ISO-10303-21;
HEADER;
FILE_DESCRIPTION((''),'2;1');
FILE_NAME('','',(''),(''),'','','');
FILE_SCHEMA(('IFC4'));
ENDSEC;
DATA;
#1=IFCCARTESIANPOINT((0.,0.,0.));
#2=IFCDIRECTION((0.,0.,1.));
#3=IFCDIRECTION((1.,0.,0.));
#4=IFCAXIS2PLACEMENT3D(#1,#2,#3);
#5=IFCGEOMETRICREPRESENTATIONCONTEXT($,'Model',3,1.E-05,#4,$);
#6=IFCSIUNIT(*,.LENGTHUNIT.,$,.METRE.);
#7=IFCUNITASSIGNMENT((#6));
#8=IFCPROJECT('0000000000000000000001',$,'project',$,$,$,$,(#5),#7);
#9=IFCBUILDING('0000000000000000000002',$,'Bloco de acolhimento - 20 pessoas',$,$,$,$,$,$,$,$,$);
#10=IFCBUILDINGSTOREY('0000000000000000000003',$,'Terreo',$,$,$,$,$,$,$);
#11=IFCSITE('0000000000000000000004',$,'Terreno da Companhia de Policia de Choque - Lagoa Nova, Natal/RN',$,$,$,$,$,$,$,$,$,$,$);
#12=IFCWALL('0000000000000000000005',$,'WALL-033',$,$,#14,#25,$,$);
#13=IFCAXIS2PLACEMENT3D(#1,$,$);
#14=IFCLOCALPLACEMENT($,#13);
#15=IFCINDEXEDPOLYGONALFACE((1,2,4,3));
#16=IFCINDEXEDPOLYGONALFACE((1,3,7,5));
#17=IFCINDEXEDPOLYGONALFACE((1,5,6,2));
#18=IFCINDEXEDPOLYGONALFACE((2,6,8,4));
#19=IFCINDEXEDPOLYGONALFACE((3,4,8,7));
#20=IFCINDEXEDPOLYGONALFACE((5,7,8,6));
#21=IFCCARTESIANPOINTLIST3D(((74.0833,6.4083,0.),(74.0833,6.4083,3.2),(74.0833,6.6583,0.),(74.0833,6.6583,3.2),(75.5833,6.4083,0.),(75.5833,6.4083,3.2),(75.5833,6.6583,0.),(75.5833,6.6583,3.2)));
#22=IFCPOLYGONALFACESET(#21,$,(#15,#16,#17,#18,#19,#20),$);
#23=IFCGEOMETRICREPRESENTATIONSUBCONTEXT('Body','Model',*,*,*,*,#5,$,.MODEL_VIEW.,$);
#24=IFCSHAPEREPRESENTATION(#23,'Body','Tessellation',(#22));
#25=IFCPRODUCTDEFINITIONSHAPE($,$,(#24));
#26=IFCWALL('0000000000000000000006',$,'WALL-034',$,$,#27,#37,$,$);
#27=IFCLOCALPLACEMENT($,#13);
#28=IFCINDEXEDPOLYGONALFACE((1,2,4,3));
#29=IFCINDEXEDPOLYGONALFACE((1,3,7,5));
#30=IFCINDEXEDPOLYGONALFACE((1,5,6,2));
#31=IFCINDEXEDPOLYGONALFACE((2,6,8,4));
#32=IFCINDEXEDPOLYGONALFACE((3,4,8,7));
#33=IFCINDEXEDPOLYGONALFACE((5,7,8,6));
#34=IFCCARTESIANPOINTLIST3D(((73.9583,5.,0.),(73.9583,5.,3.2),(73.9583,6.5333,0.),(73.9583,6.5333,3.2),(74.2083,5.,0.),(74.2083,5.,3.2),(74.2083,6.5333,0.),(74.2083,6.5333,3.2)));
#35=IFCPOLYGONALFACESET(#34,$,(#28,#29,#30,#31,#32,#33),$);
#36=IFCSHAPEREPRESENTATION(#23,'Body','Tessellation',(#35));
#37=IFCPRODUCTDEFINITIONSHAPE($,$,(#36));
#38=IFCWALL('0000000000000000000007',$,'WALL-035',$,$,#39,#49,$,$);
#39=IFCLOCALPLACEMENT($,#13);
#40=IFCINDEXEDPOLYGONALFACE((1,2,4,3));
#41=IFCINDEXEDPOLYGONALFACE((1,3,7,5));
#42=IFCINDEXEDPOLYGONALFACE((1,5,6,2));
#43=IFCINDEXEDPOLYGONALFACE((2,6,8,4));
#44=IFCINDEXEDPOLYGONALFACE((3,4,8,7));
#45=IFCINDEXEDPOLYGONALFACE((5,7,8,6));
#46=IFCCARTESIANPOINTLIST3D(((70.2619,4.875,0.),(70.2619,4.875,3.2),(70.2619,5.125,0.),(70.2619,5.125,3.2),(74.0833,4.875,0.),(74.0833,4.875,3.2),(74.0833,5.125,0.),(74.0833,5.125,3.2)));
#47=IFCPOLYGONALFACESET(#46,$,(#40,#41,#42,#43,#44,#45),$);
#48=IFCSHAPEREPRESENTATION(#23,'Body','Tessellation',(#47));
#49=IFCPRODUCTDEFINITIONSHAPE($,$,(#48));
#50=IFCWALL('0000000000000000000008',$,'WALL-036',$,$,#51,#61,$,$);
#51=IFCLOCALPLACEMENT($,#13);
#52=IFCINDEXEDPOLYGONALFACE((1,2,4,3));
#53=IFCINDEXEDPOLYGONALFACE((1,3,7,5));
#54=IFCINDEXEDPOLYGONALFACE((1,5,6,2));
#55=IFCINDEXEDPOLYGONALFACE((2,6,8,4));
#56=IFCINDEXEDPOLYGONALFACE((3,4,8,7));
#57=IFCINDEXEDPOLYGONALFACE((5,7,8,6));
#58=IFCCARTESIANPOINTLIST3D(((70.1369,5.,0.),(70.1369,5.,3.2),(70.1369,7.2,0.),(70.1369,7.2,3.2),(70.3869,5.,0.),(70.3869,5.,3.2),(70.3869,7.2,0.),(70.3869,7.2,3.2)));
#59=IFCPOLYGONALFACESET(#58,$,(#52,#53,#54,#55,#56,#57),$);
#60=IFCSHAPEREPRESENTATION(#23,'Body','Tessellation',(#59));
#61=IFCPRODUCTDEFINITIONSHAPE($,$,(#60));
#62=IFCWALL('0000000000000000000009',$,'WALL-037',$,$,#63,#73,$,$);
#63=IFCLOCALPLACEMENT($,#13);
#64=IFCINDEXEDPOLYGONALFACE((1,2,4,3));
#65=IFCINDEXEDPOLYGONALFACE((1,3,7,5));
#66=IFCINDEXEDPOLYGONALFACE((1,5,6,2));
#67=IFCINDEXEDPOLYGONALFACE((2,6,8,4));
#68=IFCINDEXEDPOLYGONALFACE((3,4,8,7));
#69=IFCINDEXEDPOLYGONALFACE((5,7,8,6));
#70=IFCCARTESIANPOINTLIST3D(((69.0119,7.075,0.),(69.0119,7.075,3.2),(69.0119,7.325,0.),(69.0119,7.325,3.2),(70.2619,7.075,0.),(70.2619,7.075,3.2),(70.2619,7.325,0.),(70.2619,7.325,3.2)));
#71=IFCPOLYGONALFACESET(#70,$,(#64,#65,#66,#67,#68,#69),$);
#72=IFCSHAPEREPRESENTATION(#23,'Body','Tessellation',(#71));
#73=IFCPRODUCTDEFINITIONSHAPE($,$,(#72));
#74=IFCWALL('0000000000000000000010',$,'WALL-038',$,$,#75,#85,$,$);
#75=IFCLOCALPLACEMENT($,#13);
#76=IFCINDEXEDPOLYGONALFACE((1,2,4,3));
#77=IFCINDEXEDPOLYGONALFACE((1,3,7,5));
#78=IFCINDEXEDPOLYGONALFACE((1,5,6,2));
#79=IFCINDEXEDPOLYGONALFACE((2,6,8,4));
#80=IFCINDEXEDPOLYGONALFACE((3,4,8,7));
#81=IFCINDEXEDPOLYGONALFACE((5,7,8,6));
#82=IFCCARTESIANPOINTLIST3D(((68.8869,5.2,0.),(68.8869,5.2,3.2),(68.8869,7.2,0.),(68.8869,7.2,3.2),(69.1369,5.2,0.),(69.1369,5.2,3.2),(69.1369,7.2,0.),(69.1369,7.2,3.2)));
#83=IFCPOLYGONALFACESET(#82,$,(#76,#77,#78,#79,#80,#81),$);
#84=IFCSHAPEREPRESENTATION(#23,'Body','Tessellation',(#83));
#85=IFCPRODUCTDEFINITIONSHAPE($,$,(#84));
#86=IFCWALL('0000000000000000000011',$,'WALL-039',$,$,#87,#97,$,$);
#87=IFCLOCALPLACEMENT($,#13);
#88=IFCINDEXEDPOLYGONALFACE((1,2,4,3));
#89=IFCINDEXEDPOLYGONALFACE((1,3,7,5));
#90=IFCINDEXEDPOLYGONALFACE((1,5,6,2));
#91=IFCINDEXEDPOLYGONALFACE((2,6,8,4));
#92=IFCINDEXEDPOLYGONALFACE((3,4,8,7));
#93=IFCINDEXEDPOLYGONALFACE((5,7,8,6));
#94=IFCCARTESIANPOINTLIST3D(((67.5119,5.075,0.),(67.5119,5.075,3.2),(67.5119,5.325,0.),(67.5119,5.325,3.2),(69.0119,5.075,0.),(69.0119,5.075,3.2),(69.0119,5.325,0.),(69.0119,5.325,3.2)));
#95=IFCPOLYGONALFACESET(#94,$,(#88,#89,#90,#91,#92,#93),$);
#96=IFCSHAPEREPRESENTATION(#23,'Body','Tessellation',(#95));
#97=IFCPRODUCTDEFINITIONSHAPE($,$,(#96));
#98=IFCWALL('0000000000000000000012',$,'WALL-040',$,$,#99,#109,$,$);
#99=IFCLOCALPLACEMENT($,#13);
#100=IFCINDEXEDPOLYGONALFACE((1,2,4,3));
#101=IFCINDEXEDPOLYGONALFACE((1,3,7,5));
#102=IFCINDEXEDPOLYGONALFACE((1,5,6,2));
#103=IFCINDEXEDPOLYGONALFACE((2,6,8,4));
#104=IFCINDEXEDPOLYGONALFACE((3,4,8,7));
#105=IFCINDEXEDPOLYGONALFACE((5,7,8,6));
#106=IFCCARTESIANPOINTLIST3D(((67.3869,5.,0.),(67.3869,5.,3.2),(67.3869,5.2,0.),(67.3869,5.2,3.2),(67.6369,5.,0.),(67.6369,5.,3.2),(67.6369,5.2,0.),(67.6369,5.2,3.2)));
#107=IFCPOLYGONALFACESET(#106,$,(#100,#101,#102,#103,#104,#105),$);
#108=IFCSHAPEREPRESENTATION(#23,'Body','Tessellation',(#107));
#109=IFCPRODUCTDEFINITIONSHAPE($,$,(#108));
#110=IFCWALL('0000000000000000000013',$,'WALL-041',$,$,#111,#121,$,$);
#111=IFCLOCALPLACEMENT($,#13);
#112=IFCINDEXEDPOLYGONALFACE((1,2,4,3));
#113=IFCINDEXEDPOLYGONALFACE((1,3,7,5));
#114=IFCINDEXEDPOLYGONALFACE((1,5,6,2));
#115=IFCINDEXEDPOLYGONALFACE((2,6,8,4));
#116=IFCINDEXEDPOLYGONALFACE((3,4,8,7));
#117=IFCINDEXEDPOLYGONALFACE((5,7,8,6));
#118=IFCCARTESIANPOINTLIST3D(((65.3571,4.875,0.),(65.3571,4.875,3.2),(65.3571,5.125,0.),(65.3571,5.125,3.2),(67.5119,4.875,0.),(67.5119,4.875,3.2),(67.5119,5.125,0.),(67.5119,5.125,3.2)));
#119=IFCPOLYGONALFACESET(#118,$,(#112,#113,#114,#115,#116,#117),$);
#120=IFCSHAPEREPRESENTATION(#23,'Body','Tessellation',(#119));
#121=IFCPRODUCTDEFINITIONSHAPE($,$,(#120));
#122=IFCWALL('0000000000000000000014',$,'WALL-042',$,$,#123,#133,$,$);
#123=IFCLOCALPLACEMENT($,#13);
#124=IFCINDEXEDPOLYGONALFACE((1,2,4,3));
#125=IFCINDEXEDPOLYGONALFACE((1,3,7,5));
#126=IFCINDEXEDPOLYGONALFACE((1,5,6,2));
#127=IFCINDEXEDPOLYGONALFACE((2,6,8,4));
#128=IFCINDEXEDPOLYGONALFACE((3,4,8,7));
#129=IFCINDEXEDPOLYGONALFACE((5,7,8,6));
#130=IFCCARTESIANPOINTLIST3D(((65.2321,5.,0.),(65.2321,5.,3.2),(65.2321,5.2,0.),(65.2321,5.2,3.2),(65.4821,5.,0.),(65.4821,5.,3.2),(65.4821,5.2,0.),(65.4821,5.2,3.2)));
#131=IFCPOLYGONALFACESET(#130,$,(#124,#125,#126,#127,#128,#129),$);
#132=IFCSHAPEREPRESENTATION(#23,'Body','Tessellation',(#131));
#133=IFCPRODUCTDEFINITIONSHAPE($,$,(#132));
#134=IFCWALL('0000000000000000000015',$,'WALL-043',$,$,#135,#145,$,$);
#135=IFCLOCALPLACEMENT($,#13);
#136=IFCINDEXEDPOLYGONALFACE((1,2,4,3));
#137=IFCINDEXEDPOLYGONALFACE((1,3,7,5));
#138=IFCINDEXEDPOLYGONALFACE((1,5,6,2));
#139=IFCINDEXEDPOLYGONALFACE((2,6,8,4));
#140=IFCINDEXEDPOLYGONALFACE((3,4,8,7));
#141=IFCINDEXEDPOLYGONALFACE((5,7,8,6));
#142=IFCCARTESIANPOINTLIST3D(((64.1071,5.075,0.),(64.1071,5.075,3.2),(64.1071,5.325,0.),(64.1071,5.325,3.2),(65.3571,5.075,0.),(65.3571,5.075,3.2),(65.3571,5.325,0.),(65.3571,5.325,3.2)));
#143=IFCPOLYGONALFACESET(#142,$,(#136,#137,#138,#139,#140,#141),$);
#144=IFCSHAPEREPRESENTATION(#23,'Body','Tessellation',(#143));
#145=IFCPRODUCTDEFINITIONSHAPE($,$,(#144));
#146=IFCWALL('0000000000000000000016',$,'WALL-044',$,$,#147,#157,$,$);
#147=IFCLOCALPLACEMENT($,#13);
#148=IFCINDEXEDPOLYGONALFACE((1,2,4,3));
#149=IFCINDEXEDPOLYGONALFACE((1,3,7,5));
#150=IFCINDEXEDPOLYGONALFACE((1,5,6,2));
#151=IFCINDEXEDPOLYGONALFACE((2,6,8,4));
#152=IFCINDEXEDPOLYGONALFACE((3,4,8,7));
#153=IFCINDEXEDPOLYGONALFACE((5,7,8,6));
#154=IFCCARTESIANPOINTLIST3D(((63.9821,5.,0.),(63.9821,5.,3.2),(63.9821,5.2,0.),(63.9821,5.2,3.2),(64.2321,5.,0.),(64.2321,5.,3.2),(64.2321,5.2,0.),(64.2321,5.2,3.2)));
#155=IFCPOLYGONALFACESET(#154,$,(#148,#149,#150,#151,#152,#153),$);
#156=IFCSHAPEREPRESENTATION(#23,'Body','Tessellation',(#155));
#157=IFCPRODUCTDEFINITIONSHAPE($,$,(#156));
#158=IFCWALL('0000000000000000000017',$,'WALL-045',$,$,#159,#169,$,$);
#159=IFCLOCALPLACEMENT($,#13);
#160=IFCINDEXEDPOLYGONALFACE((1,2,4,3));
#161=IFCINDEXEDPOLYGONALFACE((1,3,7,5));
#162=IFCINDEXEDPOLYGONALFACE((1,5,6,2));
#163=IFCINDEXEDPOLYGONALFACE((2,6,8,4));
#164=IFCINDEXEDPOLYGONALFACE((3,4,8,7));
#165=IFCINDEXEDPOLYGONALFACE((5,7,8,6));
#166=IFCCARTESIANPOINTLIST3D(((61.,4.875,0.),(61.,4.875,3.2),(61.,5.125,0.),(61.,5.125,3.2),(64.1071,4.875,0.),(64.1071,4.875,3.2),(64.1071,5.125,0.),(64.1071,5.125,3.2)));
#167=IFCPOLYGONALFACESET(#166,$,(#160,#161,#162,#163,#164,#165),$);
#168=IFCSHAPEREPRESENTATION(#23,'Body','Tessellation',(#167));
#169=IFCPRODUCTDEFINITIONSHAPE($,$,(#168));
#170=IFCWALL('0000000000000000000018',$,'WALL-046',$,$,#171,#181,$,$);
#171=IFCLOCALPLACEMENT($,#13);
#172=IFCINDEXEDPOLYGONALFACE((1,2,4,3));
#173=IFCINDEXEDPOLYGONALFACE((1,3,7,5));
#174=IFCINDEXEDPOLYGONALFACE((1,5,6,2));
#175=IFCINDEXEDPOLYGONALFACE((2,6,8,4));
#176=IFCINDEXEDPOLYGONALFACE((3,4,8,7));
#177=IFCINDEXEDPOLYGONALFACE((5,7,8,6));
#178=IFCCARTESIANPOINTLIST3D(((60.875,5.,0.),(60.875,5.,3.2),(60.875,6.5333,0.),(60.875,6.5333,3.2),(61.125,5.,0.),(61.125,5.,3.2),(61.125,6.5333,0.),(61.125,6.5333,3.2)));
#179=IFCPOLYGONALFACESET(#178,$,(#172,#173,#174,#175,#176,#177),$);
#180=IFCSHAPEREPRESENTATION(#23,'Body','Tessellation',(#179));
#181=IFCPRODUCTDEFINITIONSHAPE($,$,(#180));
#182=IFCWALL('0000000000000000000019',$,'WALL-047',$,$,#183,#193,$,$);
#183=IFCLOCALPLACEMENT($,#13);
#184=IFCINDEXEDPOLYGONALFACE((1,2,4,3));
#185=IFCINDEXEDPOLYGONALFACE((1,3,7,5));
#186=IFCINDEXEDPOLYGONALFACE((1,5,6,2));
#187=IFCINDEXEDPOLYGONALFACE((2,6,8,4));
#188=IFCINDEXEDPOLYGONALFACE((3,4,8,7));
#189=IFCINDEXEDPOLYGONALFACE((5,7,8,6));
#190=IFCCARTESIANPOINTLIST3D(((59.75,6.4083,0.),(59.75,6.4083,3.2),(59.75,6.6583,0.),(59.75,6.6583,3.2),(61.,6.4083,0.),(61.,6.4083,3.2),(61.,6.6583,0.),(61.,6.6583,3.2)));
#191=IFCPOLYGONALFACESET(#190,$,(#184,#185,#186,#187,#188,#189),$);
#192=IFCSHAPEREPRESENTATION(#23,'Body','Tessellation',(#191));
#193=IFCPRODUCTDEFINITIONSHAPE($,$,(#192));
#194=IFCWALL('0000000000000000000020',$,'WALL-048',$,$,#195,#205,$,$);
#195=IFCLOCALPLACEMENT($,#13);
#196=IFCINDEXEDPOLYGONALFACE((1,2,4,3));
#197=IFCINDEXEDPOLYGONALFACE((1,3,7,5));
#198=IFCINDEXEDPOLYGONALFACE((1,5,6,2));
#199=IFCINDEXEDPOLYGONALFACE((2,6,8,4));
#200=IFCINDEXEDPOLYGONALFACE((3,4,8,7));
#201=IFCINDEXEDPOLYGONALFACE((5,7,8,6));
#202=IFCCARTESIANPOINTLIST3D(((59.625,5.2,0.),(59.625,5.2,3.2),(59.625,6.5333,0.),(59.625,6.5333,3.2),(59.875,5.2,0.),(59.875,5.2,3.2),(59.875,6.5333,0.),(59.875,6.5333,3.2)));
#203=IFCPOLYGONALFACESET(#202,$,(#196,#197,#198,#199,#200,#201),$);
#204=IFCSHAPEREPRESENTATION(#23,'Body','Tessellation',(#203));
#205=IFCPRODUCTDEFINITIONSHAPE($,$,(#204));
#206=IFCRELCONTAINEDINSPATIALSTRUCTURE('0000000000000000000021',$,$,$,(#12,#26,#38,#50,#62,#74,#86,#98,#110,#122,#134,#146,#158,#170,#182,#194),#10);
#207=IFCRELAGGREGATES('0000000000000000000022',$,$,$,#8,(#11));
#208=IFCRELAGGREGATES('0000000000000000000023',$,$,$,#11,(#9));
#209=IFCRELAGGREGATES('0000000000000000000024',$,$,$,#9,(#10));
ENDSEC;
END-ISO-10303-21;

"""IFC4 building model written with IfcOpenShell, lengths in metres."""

from ifc_helpers import new_model, si_unit, origin_with_axes, place, context, subcontext, project, spatial, polyline, outline, extrude, element, save


model = new_model("IFC4")

# Units and contexts
model_context = context("Model", 3, precision=1e-05, world=origin_with_axes())
body_context = subcontext(model_context, "Body", "Model", "MODEL_VIEW")
ifc_project = project(units=[si_unit("LENGTHUNIT", "METRE")], contexts=[model_context])

# Site, building, storey
site = spatial("IfcSite", under=ifc_project, Name="Terreno da Companhia de Policia de Choque - Lagoa Nova, Natal/RN")
building = spatial("IfcBuilding", under=site, Name="Bloco de acolhimento - 20 pessoas")
storey = spatial("IfcBuildingStorey", under=building, Name="Terreo")

# Walls
wall_1_placement = place(None, origin_with_axes())
element("IfcWall", 1, at=wall_1_placement, inside=storey, Name="WALL-033", context=body_context, shape_type="SweptSolid", body=[
    extrude(outline(polyline([(75.5833, 6.4083, 0.0), (75.5833, 6.6583, 0.0), (74.0833, 6.6583, 0.0), (74.0833, 6.4083, 0.0), (75.5833, 6.4083, 0.0)])), None, (0.0, 0.0, 1.0), 3.2),
])
wall_2_placement = place(None, origin_with_axes())
element("IfcWall", 2, at=wall_2_placement, inside=storey, Name="WALL-034", context=body_context, shape_type="SweptSolid", body=[
    extrude(outline(polyline([(74.2083, 5.0, 0.0), (74.2083, 6.5333, 0.0), (73.9583, 6.5333, 0.0), (73.9583, 5.0, 0.0), (74.2083, 5.0, 0.0)])), None, (0.0, 0.0, 1.0), 3.2),
])
wall_3_placement = place(None, origin_with_axes())
element("IfcWall", 3, at=wall_3_placement, inside=storey, Name="WALL-035", context=body_context, shape_type="SweptSolid", body=[
    extrude(outline(polyline([(74.0833, 4.875, 0.0), (74.0833, 5.125, 0.0), (70.2619, 5.125, 0.0), (70.2619, 4.875, 0.0), (74.0833, 4.875, 0.0)])), None, (0.0, 0.0, 1.0), 3.2),
])
wall_4_placement = place(None, origin_with_axes())
element("IfcWall", 4, at=wall_4_placement, inside=storey, Name="WALL-036", context=body_context, shape_type="SweptSolid", body=[
    extrude(outline(polyline([(70.3869, 5.0, 0.0), (70.3869, 7.2, 0.0), (70.1369, 7.2, 0.0), (70.1369, 5.0, 0.0), (70.3869, 5.0, 0.0)])), None, (0.0, 0.0, 1.0), 3.2),
])
wall_5_placement = place(None, origin_with_axes())
element("IfcWall", 5, at=wall_5_placement, inside=storey, Name="WALL-037", context=body_context, shape_type="SweptSolid", body=[
    extrude(outline(polyline([(70.2619, 7.075, 0.0), (70.2619, 7.325, 0.0), (69.0119, 7.325, 0.0), (69.0119, 7.075, 0.0), (70.2619, 7.075, 0.0)])), None, (0.0, 0.0, 1.0), 3.2),
])
wall_6_placement = place(None, origin_with_axes())
element("IfcWall", 6, at=wall_6_placement, inside=storey, Name="WALL-038", context=body_context, shape_type="SweptSolid", body=[
    extrude(outline(polyline([(69.1369, 5.2, 0.0), (69.1369, 7.2, 0.0), (68.8869, 7.2, 0.0), (68.8869, 5.2, 0.0), (69.1369, 5.2, 0.0)])), None, (0.0, 0.0, 1.0), 3.2),
])
wall_7_placement = place(None, origin_with_axes())
element("IfcWall", 7, at=wall_7_placement, inside=storey, Name="WALL-039", context=body_context, shape_type="SweptSolid", body=[
    extrude(outline(polyline([(69.0119, 5.075, 0.0), (69.0119, 5.325, 0.0), (67.5119, 5.325, 0.0), (67.5119, 5.075, 0.0), (69.0119, 5.075, 0.0)])), None, (0.0, 0.0, 1.0), 3.2),
])
wall_8_placement = place(None, origin_with_axes())
element("IfcWall", 8, at=wall_8_placement, inside=storey, Name="WALL-040", context=body_context, shape_type="SweptSolid", body=[
    extrude(outline(polyline([(67.6369, 5.0, 0.0), (67.6369, 5.2, 0.0), (67.3869, 5.2, 0.0), (67.3869, 5.0, 0.0), (67.6369, 5.0, 0.0)])), None, (0.0, 0.0, 1.0), 3.2),
])
wall_9_placement = place(None, origin_with_axes())
element("IfcWall", 9, at=wall_9_placement, inside=storey, Name="WALL-041", context=body_context, shape_type="SweptSolid", body=[
    extrude(outline(polyline([(67.5119, 4.875, 0.0), (67.5119, 5.125, 0.0), (65.3571, 5.125, 0.0), (65.3571, 4.875, 0.0), (67.5119, 4.875, 0.0)])), None, (0.0, 0.0, 1.0), 3.2),
])
wall_10_placement = place(None, origin_with_axes())
element("IfcWall", 10, at=wall_10_placement, inside=storey, Name="WALL-042", context=body_context, shape_type="SweptSolid", body=[
    extrude(outline(polyline([(65.4821, 5.0, 0.0), (65.4821, 5.2, 0.0), (65.2321, 5.2, 0.0), (65.2321, 5.0, 0.0), (65.4821, 5.0, 0.0)])), None, (0.0, 0.0, 1.0), 3.2),
])
wall_11_placement = place(None, origin_with_axes())
element("IfcWall", 11, at=wall_11_placement, inside=storey, Name="WALL-043", context=body_context, shape_type="SweptSolid", body=[
    extrude(outline(polyline([(65.3571, 5.075, 0.0), (65.3571, 5.325, 0.0), (64.1071, 5.325, 0.0), (64.1071, 5.075, 0.0), (65.3571, 5.075, 0.0)])), None, (0.0, 0.0, 1.0), 3.2),
])
wall_12_placement = place(None, origin_with_axes())
element("IfcWall", 12, at=wall_12_placement, inside=storey, Name="WALL-044", context=body_context, shape_type="SweptSolid", body=[
    extrude(outline(polyline([(64.2321, 5.0, 0.0), (64.2321, 5.2, 0.0), (63.9821, 5.2, 0.0), (63.9821, 5.0, 0.0), (64.2321, 5.0, 0.0)])), None, (0.0, 0.0, 1.0), 3.2),
])
wall_13_placement = place(None, origin_with_axes())
element("IfcWall", 13, at=wall_13_placement, inside=storey, Name="WALL-045", context=body_context, shape_type="SweptSolid", body=[
    extrude(outline(polyline([(64.1071, 4.875, 0.0), (64.1071, 5.125, 0.0), (61.0, 5.125, 0.0), (61.0, 4.875, 0.0), (64.1071, 4.875, 0.0)])), None, (0.0, 0.0, 1.0), 3.2),
])
wall_14_placement = place(None, origin_with_axes())
element("IfcWall", 14, at=wall_14_placement, inside=storey, Name="WALL-046", context=body_context, shape_type="SweptSolid", body=[
    extrude(outline(polyline([(61.125, 5.0, 0.0), (61.125, 6.5333, 0.0), (60.875, 6.5333, 0.0), (60.875, 5.0, 0.0), (61.125, 5.0, 0.0)])), None, (0.0, 0.0, 1.0), 3.2),
])
wall_15_placement = place(None, origin_with_axes())
element("IfcWall", 15, at=wall_15_placement, inside=storey, Name="WALL-047", context=body_context, shape_type="SweptSolid", body=[
    extrude(outline(polyline([(61.0, 6.4083, 0.0), (61.0, 6.6583, 0.0), (59.75, 6.6583, 0.0), (59.75, 6.4083, 0.0), (61.0, 6.4083, 0.0)])), None, (0.0, 0.0, 1.0), 3.2),
])
wall_16_placement = place(None, origin_with_axes())
element("IfcWall", 16, at=wall_16_placement, inside=storey, Name="WALL-048", context=body_context, shape_type="SweptSolid", body=[
    extrude(outline(polyline([(59.875, 5.2, 0.0), (59.875, 6.5333, 0.0), (59.625, 6.5333, 0.0), (59.625, 5.2, 0.0), (59.875, 5.2, 0.0)])), None, (0.0, 0.0, 1.0), 3.2),
])

save(model, "model.ifc")
